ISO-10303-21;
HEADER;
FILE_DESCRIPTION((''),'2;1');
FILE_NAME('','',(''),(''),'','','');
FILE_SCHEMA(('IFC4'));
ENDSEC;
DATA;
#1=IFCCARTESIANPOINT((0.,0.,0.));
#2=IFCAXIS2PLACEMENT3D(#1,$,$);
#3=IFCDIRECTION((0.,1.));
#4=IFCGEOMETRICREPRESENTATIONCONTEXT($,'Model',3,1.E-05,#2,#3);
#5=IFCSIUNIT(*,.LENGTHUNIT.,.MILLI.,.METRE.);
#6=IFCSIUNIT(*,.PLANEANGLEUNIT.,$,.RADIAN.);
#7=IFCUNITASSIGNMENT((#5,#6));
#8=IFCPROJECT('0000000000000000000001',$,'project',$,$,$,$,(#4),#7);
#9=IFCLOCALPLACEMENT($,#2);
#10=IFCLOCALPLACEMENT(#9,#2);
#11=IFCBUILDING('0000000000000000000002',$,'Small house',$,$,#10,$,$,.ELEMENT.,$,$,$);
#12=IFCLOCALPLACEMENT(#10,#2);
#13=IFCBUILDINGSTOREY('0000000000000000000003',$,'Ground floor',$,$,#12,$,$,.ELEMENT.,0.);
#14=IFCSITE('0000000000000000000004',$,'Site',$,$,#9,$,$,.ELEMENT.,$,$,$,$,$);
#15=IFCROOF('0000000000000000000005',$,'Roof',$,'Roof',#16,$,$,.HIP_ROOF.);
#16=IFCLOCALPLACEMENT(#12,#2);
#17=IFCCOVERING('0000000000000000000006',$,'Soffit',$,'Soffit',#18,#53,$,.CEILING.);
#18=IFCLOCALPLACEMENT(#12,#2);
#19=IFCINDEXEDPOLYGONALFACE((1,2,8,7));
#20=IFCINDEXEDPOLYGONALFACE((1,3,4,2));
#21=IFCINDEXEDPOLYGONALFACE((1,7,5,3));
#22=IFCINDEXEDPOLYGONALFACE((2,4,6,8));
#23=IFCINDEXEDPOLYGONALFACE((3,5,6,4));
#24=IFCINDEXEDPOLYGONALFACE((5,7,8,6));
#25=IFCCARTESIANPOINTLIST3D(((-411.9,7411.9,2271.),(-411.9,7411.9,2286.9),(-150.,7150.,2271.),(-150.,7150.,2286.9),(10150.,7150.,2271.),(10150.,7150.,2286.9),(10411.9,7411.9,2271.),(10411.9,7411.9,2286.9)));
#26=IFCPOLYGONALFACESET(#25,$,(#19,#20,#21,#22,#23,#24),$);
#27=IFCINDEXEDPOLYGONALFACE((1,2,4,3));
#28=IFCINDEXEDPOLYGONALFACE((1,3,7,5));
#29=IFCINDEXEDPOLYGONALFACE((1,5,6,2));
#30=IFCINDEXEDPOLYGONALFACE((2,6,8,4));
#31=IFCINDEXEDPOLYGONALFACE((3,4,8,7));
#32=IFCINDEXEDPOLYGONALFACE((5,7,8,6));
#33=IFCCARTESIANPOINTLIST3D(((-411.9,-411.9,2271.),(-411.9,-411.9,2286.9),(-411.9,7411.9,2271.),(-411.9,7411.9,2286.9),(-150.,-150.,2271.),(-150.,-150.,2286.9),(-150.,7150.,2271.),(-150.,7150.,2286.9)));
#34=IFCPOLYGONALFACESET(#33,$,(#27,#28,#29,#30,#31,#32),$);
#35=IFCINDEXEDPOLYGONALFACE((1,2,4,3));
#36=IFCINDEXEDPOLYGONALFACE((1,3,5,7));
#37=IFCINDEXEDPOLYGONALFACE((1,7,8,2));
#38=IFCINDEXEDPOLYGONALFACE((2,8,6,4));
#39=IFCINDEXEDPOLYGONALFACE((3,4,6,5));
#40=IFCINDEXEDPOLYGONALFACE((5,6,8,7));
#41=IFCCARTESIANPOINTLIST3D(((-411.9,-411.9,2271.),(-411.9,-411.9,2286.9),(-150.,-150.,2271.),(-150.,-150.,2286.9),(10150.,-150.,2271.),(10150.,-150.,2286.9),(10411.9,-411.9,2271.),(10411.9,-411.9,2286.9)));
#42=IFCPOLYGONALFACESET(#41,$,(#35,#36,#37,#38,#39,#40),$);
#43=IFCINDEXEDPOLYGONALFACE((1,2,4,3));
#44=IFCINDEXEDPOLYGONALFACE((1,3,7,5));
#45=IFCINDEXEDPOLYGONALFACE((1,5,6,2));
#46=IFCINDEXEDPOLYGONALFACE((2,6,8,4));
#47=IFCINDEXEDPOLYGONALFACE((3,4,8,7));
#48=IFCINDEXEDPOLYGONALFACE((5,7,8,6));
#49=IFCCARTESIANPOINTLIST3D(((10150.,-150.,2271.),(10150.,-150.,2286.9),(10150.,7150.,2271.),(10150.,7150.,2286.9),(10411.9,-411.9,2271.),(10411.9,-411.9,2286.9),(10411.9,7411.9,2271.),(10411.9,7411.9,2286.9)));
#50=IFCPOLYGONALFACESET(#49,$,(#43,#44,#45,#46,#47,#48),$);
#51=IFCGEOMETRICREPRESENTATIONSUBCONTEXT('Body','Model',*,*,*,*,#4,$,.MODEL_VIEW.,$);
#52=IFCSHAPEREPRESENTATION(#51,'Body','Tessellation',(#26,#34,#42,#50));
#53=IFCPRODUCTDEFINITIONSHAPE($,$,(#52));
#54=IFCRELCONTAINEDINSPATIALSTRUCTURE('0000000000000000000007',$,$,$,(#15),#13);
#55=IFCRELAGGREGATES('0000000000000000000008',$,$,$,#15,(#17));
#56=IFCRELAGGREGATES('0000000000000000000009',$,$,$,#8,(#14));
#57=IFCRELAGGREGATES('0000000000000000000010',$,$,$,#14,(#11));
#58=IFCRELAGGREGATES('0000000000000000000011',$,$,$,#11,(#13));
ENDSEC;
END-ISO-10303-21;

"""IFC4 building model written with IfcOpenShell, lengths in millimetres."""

from ifc_helpers import new_model, si_unit, direction, frame, origin, origin_with_axes, place, context, subcontext, project, spatial, polyline, outline, extrude, element, aggregate, save


model = new_model("IFC4")

# Units and contexts
model_context = context("Model", 3, precision=1e-05, world=origin(), true_north=direction((0.0, 1.0)))
body_context = subcontext(model_context, "Body", "Model", "MODEL_VIEW")
ifc_project = project(units=[si_unit("LENGTHUNIT", "METRE", prefix="MILLI"), si_unit("PLANEANGLEUNIT", "RADIAN")], contexts=[model_context])

# Site, building, storey
site_placement = place(None, origin())
site = spatial("IfcSite", under=ifc_project, at=site_placement, Name="Site", CompositionType="ELEMENT")
building_placement = place(site_placement, origin())
building = spatial("IfcBuilding", under=site, at=building_placement, Name="Small house", CompositionType="ELEMENT")
storey_placement = place(building_placement, origin())
storey = spatial("IfcBuildingStorey", under=building, at=storey_placement, Name="Ground floor", CompositionType="ELEMENT", Elevation=0.0)

# Roof
roof_placement = place(storey_placement, origin_with_axes())
roof = element("IfcRoof", 1, at=roof_placement, inside=storey, Name="Roof", ObjectType="Roof", PredefinedType="HIP_ROOF")

# Covering
covering_1_placement = place(storey_placement, origin_with_axes())
covering_1 = element("IfcCovering", 2, at=covering_1_placement, Name="Soffit", ObjectType="Soffit", PredefinedType="CEILING", context=body_context, shape_type="SweptSolid", body=[
    extrude(outline(polyline([(10150.0, 7150.0), (-150.0, 7150.0), (-411.9, 7411.9), (10411.9, 7411.9), (10150.0, 7150.0)])), frame((0.0, 0.0, 2271.0), z_axis=(0.0, 0.0, 1.0), x_axis=(1.0, 0.0, 0.0)), (0.0, 0.0, 1.0), 15.9),
    extrude(outline(polyline([(-150.0, 7150.0), (-150.0, -150.0), (-411.9, -411.9), (-411.9, 7411.9), (-150.0, 7150.0)])), frame((0.0, 0.0, 2271.0), z_axis=(0.0, 0.0, 1.0), x_axis=(1.0, 0.0, 0.0)), (0.0, 0.0, 1.0), 15.9),
    extrude(outline(polyline([(-150.0, -150.0), (10150.0, -150.0), (10411.9, -411.9), (-411.9, -411.9), (-150.0, -150.0)])), frame((0.0, 0.0, 2271.0), z_axis=(0.0, 0.0, 1.0), x_axis=(1.0, 0.0, 0.0)), (0.0, 0.0, 1.0), 15.9),
    extrude(outline(polyline([(10150.0, -150.0), (10150.0, 7150.0), (10411.9, 7411.9), (10411.9, -411.9), (10150.0, -150.0)])), frame((0.0, 0.0, 2271.0), z_axis=(0.0, 0.0, 1.0), x_axis=(1.0, 0.0, 0.0)), (0.0, 0.0, 1.0), 15.9),
])
aggregate(roof, [covering_1])

save(model, "model.ifc")
